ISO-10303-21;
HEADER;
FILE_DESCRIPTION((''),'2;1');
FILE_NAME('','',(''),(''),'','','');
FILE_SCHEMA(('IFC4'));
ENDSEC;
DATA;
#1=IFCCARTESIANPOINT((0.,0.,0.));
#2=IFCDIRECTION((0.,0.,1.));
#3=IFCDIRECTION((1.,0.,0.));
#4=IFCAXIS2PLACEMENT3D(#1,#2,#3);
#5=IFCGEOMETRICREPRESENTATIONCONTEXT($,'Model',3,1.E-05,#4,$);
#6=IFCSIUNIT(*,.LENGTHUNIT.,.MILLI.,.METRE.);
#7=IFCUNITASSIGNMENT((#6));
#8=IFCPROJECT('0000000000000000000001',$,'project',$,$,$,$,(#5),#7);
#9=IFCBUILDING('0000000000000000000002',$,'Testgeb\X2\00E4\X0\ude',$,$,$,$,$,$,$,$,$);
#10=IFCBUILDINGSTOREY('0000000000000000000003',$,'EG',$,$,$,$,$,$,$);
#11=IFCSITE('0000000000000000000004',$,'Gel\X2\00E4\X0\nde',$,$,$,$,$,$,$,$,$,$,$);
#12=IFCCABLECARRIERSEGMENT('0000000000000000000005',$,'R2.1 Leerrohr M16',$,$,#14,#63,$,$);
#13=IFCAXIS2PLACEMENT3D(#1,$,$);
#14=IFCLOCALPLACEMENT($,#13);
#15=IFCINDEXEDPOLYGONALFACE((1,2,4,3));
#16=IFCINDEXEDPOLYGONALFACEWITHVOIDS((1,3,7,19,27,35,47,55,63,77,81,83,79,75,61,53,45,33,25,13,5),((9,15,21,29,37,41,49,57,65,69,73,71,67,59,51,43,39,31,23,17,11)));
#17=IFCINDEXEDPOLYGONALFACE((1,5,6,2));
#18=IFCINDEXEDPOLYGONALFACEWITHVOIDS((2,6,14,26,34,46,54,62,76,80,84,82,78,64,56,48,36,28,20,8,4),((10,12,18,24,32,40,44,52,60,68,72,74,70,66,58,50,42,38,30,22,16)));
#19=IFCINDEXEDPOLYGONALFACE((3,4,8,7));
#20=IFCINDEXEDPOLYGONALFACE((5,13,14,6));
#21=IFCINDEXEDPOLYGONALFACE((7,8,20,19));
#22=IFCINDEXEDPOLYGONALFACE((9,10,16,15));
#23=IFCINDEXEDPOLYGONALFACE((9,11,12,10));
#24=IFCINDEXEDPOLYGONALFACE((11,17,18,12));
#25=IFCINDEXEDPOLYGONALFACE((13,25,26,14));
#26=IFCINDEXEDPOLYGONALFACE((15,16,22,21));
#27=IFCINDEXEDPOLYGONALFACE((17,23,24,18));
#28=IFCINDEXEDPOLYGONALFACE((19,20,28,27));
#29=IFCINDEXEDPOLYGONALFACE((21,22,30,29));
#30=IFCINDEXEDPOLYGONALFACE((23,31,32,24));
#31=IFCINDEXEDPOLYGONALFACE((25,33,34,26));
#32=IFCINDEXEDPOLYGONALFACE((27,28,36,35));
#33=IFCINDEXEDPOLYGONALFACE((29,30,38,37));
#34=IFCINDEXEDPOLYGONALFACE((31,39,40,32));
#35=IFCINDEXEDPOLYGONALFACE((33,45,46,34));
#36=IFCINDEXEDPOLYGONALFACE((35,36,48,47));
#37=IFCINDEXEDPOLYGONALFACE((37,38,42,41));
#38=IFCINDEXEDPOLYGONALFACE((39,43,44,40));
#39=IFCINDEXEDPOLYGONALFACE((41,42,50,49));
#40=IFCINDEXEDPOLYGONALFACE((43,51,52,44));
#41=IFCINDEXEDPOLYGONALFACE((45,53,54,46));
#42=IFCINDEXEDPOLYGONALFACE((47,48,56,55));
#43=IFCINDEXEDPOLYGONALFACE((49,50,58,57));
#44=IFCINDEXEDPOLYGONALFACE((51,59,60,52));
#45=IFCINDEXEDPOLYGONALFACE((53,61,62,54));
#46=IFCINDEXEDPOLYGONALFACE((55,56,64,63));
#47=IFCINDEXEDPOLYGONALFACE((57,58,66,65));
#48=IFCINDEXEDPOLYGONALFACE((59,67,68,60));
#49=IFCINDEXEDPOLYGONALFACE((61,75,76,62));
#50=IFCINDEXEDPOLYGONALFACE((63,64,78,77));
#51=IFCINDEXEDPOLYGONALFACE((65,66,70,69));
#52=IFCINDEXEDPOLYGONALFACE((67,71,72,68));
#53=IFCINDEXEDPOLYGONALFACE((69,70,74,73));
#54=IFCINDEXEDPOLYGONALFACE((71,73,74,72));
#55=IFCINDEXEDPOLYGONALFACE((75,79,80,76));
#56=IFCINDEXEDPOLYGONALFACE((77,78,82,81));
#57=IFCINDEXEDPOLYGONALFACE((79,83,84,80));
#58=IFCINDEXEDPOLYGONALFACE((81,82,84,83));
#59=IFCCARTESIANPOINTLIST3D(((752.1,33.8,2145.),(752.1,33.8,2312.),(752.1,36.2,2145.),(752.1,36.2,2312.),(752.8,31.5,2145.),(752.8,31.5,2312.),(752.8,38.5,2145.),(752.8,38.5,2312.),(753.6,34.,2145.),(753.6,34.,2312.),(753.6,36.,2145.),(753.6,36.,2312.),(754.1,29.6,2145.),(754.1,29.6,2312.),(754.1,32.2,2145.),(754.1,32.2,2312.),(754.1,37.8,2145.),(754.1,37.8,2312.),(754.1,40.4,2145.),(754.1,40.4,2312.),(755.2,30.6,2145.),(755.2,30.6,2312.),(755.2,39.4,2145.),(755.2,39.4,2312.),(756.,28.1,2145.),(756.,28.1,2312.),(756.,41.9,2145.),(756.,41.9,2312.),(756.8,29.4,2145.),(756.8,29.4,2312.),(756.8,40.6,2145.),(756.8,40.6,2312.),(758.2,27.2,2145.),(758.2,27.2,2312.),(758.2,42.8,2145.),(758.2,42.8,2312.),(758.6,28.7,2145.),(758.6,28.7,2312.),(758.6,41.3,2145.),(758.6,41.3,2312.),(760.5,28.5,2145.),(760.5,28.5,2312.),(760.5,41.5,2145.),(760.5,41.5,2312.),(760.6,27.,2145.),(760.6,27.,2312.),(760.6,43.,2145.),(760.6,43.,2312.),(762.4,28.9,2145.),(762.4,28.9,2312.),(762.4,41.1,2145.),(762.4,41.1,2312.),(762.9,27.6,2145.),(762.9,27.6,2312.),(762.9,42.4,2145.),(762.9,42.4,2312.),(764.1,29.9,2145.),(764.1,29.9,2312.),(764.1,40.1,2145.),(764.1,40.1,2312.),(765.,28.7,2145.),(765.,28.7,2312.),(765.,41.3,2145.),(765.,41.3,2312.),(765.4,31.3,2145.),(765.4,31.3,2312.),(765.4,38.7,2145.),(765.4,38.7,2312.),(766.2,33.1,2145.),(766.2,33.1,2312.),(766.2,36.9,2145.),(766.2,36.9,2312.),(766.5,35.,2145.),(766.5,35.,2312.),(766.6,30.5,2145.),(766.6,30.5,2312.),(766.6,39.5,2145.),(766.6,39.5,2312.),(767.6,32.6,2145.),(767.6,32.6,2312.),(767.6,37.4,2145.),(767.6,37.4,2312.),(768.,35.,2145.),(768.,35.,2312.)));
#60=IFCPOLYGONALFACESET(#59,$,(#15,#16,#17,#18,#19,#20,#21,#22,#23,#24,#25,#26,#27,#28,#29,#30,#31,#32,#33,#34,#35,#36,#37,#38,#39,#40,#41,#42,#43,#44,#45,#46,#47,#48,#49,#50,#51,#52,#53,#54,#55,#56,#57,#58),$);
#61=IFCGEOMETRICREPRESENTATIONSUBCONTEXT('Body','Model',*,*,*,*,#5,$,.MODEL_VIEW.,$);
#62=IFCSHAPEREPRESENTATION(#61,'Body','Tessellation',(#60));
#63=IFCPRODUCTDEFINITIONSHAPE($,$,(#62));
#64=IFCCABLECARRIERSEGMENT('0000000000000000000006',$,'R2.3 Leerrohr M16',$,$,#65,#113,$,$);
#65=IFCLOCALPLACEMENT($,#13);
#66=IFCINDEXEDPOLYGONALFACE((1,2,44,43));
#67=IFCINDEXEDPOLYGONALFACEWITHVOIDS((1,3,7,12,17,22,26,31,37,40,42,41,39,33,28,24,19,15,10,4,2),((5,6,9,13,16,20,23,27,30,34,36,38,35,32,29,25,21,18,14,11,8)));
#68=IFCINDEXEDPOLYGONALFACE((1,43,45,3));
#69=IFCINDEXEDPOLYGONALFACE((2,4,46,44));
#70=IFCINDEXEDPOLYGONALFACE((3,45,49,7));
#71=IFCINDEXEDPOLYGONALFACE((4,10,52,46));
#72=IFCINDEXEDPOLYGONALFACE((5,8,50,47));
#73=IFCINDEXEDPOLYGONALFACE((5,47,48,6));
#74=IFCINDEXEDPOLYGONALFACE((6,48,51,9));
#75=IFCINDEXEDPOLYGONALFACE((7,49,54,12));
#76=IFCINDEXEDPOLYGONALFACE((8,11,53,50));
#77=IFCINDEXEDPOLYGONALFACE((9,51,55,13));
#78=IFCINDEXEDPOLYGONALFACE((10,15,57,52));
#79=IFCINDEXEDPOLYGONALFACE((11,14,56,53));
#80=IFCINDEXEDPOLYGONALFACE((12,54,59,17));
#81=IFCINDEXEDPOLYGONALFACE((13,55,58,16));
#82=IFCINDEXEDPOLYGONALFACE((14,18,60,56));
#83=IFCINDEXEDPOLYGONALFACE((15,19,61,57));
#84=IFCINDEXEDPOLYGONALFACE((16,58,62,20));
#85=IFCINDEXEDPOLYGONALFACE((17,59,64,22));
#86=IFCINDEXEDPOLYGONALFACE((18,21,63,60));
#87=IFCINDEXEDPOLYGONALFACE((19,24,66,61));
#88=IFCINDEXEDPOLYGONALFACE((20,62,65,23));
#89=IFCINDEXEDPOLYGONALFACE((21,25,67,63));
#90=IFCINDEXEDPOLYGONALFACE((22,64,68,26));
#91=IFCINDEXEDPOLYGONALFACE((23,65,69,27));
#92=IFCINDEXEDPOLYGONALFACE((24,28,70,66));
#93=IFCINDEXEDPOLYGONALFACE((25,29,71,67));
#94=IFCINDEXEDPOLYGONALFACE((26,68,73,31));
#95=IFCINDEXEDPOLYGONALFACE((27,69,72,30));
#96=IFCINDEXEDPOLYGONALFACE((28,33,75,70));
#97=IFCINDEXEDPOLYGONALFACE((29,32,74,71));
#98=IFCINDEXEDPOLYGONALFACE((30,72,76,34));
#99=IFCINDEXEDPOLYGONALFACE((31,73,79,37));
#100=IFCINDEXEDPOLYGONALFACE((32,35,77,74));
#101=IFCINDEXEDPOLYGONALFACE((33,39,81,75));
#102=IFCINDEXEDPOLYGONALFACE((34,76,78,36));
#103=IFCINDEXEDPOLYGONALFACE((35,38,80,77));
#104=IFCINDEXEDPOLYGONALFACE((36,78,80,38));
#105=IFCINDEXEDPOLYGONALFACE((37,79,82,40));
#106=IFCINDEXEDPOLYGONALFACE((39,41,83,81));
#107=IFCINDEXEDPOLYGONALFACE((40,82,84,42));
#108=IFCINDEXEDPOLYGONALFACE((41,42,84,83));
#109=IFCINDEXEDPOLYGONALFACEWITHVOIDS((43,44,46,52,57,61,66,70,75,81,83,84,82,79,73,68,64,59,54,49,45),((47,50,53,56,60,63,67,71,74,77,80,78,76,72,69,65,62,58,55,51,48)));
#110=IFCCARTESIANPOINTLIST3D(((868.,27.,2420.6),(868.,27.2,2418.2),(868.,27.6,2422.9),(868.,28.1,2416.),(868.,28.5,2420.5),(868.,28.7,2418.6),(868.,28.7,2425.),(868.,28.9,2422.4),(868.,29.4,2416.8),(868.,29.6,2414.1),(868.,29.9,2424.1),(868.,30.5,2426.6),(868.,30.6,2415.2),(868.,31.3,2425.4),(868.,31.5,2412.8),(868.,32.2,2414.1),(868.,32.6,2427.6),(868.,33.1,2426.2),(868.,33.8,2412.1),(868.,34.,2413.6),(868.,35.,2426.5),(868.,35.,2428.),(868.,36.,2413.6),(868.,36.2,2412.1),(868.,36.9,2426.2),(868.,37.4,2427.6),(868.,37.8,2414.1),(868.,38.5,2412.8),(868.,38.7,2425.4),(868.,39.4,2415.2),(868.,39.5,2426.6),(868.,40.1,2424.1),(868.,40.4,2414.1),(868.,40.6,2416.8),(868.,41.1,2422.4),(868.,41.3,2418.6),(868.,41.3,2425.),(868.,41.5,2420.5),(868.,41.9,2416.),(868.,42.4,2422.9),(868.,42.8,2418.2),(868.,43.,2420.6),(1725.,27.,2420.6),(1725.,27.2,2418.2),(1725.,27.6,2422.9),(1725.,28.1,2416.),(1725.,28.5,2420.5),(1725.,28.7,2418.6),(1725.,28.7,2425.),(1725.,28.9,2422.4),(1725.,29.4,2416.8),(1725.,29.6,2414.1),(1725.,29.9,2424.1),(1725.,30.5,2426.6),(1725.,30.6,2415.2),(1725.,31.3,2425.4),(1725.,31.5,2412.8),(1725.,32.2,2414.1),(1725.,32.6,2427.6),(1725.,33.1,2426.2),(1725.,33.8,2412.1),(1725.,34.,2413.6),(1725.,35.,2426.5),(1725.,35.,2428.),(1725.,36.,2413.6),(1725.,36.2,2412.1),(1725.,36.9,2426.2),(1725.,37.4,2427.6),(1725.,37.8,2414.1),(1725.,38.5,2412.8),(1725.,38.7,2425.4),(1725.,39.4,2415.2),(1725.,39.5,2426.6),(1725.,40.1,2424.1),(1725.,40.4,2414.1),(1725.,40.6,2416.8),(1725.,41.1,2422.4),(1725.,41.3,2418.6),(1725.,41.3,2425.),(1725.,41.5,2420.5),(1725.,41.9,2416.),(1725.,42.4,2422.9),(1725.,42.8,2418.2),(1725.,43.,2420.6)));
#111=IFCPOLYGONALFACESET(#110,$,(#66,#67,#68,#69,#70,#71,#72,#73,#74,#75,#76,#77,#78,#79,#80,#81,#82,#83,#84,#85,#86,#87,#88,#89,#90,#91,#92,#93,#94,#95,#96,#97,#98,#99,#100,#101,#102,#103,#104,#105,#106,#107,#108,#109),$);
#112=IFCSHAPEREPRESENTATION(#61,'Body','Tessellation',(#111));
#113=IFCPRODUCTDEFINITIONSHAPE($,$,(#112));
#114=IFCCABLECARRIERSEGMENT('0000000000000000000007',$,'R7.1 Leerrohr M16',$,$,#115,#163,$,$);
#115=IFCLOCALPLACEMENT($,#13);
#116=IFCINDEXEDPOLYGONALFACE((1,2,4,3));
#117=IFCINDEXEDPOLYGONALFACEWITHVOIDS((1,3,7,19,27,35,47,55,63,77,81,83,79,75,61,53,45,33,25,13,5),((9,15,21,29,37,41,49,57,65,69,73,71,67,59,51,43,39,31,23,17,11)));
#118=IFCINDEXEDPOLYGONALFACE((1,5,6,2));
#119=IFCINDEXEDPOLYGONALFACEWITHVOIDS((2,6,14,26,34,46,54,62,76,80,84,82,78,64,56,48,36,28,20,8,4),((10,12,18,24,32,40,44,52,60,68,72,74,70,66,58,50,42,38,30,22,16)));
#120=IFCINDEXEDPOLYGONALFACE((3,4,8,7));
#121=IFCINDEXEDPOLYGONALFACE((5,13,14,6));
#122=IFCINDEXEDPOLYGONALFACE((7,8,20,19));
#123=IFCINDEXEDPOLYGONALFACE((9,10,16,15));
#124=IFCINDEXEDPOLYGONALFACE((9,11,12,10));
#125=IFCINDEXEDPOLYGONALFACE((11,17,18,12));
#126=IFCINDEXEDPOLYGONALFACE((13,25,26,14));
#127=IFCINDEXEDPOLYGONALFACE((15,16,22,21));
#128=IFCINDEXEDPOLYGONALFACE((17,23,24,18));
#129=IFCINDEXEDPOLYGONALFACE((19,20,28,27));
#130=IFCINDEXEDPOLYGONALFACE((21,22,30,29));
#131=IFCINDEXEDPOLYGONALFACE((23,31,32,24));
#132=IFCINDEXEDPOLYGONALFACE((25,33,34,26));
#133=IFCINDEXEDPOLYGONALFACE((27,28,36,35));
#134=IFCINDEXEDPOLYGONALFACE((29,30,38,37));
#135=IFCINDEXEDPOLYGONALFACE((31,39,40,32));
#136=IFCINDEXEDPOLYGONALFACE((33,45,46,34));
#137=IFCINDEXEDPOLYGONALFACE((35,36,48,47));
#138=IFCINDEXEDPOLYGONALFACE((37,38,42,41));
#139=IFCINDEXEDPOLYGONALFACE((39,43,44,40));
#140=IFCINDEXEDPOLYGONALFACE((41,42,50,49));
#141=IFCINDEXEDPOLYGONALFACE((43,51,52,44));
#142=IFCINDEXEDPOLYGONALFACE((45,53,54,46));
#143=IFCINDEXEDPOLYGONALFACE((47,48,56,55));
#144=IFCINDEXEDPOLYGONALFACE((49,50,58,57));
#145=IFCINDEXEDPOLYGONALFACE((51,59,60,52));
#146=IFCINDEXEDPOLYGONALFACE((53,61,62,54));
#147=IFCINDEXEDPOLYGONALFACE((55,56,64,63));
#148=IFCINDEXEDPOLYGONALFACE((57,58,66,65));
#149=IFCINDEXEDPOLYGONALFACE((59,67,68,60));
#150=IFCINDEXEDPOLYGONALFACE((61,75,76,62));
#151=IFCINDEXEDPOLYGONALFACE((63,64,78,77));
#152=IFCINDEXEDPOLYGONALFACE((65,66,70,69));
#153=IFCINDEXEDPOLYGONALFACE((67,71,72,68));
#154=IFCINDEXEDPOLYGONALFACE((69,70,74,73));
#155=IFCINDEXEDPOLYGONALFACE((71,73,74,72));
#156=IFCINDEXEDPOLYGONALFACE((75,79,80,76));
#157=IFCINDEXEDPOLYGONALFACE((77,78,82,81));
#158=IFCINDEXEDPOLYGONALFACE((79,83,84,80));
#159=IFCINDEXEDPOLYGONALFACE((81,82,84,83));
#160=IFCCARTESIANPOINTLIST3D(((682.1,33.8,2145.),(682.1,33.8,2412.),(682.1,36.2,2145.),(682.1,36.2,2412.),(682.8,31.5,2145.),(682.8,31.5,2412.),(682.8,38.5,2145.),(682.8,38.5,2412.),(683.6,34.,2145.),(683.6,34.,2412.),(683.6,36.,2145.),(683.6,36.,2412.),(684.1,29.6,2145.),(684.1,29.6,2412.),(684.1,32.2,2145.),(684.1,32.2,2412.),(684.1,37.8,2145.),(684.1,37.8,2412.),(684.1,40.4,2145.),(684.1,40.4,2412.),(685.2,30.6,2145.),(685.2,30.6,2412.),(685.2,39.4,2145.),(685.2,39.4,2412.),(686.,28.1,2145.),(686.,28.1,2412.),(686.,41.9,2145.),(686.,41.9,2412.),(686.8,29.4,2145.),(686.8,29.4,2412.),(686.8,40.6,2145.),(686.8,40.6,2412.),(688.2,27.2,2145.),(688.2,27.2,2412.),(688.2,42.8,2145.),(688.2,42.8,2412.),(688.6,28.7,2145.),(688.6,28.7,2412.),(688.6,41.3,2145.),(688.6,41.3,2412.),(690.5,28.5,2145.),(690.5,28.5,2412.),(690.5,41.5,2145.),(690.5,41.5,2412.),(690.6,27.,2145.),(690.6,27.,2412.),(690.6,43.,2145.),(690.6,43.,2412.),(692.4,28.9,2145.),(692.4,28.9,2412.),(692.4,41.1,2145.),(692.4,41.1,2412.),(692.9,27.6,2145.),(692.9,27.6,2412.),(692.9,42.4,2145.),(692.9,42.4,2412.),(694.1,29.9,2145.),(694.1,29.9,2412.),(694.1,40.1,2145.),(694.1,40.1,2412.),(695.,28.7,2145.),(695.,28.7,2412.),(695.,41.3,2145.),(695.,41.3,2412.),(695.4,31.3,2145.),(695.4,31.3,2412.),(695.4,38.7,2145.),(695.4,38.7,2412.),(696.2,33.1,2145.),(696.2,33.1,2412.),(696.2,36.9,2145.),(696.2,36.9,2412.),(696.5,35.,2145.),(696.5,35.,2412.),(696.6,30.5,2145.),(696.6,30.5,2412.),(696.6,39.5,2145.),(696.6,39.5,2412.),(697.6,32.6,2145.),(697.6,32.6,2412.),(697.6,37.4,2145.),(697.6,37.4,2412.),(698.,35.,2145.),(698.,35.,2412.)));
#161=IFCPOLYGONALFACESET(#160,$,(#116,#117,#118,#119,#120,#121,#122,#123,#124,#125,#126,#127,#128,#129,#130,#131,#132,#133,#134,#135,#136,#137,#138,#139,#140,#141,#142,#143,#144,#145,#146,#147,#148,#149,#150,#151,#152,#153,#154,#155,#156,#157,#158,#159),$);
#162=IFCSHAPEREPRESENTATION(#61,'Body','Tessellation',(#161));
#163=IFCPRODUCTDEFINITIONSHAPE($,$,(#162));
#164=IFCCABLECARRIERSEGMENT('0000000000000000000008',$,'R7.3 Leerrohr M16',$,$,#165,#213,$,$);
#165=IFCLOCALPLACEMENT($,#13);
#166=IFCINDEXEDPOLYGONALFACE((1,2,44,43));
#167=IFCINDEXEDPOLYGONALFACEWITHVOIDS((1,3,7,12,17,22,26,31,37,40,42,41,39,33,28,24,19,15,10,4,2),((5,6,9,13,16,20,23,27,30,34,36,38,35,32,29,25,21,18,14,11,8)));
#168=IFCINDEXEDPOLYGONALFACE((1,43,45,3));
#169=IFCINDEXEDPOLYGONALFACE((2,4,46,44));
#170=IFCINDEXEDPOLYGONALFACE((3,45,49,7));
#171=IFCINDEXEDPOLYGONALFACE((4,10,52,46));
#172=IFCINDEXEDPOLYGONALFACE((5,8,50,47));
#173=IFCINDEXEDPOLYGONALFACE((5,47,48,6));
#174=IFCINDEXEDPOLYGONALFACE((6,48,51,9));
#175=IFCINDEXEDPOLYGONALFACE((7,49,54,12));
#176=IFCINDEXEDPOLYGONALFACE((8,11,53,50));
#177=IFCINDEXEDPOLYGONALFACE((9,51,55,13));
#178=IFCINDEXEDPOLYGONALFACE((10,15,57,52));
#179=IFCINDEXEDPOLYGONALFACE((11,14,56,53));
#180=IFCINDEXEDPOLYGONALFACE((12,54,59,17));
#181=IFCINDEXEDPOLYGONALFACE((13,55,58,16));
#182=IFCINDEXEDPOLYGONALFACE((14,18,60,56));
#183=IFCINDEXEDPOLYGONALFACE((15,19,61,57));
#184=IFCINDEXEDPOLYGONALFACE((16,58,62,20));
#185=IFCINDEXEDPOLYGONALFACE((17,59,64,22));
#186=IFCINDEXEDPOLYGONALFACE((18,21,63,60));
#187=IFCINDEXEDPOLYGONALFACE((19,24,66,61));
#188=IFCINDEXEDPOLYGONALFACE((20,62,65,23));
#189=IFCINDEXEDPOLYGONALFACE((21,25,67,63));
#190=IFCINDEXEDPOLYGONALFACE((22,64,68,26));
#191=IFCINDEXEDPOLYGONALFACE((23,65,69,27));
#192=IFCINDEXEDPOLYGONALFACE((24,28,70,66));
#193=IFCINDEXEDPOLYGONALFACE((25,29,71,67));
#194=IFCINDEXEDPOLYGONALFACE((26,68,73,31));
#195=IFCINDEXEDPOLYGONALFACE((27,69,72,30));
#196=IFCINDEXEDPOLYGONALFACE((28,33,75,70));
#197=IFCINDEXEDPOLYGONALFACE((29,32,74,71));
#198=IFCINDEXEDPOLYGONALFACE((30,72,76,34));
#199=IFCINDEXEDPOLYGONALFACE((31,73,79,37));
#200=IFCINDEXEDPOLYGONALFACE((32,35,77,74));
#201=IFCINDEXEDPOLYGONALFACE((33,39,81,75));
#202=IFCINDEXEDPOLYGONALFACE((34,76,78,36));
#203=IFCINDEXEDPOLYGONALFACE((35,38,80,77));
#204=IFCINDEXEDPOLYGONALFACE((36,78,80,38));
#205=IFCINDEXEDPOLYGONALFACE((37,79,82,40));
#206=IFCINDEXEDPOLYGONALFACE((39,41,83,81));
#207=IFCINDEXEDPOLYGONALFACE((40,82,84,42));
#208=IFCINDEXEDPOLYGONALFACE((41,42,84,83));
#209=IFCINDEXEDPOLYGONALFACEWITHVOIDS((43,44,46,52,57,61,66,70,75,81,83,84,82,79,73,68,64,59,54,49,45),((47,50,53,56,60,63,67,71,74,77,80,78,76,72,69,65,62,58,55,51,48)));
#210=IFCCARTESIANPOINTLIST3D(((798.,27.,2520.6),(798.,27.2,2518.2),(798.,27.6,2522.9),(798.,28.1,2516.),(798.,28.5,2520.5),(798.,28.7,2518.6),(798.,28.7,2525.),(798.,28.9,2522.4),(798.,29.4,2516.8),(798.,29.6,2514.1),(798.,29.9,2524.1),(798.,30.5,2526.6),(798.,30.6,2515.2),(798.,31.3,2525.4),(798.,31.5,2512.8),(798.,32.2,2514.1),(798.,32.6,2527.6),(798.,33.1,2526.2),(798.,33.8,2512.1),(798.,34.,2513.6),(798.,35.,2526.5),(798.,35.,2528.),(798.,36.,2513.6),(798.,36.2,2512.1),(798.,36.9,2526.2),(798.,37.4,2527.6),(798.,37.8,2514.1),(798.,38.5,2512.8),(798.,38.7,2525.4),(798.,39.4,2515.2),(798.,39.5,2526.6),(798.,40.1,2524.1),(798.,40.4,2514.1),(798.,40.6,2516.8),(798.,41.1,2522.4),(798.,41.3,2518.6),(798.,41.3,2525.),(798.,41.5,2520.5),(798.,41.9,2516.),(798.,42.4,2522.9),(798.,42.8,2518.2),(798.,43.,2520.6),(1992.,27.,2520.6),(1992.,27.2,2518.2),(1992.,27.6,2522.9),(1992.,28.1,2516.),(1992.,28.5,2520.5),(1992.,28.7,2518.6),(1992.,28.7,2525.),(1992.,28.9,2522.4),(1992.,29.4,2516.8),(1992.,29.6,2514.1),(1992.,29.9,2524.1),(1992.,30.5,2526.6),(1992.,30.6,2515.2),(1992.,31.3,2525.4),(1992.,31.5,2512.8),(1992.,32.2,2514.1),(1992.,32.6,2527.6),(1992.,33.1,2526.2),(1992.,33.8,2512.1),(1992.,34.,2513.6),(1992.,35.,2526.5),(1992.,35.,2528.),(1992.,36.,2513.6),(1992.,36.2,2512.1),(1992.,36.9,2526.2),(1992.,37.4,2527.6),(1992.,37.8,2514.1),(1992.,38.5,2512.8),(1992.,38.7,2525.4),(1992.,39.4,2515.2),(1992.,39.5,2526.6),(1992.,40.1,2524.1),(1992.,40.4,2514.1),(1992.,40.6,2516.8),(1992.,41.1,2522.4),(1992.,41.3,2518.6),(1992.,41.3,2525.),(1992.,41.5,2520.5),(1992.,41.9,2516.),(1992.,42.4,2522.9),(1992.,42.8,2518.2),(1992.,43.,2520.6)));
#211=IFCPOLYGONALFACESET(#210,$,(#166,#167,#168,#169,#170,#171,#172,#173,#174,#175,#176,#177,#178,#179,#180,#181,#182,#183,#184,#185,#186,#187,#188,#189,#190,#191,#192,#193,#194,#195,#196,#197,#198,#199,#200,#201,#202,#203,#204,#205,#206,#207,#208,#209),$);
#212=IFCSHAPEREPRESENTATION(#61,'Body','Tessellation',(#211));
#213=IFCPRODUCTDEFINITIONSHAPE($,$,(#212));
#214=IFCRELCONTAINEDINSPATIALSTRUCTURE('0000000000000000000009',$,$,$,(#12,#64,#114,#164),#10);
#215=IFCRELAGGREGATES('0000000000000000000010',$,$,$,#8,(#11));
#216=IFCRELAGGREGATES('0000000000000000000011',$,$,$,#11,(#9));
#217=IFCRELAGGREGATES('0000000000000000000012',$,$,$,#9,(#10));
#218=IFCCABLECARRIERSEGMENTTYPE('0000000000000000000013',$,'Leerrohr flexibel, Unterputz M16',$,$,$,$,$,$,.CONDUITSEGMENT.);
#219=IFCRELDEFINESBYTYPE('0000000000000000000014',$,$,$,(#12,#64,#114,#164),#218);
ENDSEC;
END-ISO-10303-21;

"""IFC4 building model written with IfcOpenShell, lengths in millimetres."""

from ifc_helpers import new_model, si_unit, frame, origin_with_axes, place, context, subcontext, project, spatial, hollow_circle, extrude, type_object, element, save


model = new_model("IFC4")

# Units and contexts
model_context = context("Model", 3, precision=1e-05, world=origin_with_axes())
body_context = subcontext(model_context, "Body", "Model", "MODEL_VIEW")
ifc_project = project(units=[si_unit("LENGTHUNIT", "METRE", prefix="MILLI")], contexts=[model_context])

# Site, building, storey
site = spatial("IfcSite", under=ifc_project, Name="Gelände")
building = spatial("IfcBuilding", under=site, Name="Testgebäude")
storey = spatial("IfcBuildingStorey", under=building, Name="EG")

# Cable carrier segments
cable_carrier_segment_type_1 = type_object("IfcCableCarrierSegmentType", Name="Leerrohr flexibel, Unterputz M16", PredefinedType="CONDUITSEGMENT")
cable_carrier_segment_1_placement = place(None, frame((760.0, 35.0, 2145.0), z_axis=(0.0, 0.0, 1.0), x_axis=(1.0, 0.0, 0.0)))
element("IfcCableCarrierSegment", 1, at=cable_carrier_segment_1_placement, inside=storey, type_object=cable_carrier_segment_type_1, Name="R2.1 Leerrohr M16", context=body_context, shape_type="SweptSolid", body=[
    extrude(hollow_circle(Radius=8.0, WallThickness=1.5), None, (0.0, 0.0, 1.0), 167.0),
])
cable_carrier_segment_2_placement = place(None, frame((868.0, 35.0, 2420.0), z_axis=(1.0, 0.0, 0.0), x_axis=(0.0, 0.0, 1.0)))
element("IfcCableCarrierSegment", 2, at=cable_carrier_segment_2_placement, inside=storey, type_object=cable_carrier_segment_type_1, Name="R2.3 Leerrohr M16", context=body_context, shape_type="SweptSolid", body=[
    extrude(hollow_circle(Radius=8.0, WallThickness=1.5), None, (0.0, 0.0, 1.0), 857.0),
])
cable_carrier_segment_3_placement = place(None, frame((690.0, 35.0, 2145.0), z_axis=(0.0, 0.0, 1.0), x_axis=(1.0, 0.0, 0.0)))
element("IfcCableCarrierSegment", 3, at=cable_carrier_segment_3_placement, inside=storey, type_object=cable_carrier_segment_type_1, Name="R7.1 Leerrohr M16", context=body_context, shape_type="SweptSolid", body=[
    extrude(hollow_circle(Radius=8.0, WallThickness=1.5), None, (0.0, 0.0, 1.0), 267.0),
])
cable_carrier_segment_4_placement = place(None, frame((798.0, 35.0, 2520.0), z_axis=(1.0, 0.0, 0.0), x_axis=(0.0, 0.0, 1.0)))
element("IfcCableCarrierSegment", 4, at=cable_carrier_segment_4_placement, inside=storey, type_object=cable_carrier_segment_type_1, Name="R7.3 Leerrohr M16", context=body_context, shape_type="SweptSolid", body=[
    extrude(hollow_circle(Radius=8.0, WallThickness=1.5), None, (0.0, 0.0, 1.0), 1194.0),
])

save(model, "model.ifc")
